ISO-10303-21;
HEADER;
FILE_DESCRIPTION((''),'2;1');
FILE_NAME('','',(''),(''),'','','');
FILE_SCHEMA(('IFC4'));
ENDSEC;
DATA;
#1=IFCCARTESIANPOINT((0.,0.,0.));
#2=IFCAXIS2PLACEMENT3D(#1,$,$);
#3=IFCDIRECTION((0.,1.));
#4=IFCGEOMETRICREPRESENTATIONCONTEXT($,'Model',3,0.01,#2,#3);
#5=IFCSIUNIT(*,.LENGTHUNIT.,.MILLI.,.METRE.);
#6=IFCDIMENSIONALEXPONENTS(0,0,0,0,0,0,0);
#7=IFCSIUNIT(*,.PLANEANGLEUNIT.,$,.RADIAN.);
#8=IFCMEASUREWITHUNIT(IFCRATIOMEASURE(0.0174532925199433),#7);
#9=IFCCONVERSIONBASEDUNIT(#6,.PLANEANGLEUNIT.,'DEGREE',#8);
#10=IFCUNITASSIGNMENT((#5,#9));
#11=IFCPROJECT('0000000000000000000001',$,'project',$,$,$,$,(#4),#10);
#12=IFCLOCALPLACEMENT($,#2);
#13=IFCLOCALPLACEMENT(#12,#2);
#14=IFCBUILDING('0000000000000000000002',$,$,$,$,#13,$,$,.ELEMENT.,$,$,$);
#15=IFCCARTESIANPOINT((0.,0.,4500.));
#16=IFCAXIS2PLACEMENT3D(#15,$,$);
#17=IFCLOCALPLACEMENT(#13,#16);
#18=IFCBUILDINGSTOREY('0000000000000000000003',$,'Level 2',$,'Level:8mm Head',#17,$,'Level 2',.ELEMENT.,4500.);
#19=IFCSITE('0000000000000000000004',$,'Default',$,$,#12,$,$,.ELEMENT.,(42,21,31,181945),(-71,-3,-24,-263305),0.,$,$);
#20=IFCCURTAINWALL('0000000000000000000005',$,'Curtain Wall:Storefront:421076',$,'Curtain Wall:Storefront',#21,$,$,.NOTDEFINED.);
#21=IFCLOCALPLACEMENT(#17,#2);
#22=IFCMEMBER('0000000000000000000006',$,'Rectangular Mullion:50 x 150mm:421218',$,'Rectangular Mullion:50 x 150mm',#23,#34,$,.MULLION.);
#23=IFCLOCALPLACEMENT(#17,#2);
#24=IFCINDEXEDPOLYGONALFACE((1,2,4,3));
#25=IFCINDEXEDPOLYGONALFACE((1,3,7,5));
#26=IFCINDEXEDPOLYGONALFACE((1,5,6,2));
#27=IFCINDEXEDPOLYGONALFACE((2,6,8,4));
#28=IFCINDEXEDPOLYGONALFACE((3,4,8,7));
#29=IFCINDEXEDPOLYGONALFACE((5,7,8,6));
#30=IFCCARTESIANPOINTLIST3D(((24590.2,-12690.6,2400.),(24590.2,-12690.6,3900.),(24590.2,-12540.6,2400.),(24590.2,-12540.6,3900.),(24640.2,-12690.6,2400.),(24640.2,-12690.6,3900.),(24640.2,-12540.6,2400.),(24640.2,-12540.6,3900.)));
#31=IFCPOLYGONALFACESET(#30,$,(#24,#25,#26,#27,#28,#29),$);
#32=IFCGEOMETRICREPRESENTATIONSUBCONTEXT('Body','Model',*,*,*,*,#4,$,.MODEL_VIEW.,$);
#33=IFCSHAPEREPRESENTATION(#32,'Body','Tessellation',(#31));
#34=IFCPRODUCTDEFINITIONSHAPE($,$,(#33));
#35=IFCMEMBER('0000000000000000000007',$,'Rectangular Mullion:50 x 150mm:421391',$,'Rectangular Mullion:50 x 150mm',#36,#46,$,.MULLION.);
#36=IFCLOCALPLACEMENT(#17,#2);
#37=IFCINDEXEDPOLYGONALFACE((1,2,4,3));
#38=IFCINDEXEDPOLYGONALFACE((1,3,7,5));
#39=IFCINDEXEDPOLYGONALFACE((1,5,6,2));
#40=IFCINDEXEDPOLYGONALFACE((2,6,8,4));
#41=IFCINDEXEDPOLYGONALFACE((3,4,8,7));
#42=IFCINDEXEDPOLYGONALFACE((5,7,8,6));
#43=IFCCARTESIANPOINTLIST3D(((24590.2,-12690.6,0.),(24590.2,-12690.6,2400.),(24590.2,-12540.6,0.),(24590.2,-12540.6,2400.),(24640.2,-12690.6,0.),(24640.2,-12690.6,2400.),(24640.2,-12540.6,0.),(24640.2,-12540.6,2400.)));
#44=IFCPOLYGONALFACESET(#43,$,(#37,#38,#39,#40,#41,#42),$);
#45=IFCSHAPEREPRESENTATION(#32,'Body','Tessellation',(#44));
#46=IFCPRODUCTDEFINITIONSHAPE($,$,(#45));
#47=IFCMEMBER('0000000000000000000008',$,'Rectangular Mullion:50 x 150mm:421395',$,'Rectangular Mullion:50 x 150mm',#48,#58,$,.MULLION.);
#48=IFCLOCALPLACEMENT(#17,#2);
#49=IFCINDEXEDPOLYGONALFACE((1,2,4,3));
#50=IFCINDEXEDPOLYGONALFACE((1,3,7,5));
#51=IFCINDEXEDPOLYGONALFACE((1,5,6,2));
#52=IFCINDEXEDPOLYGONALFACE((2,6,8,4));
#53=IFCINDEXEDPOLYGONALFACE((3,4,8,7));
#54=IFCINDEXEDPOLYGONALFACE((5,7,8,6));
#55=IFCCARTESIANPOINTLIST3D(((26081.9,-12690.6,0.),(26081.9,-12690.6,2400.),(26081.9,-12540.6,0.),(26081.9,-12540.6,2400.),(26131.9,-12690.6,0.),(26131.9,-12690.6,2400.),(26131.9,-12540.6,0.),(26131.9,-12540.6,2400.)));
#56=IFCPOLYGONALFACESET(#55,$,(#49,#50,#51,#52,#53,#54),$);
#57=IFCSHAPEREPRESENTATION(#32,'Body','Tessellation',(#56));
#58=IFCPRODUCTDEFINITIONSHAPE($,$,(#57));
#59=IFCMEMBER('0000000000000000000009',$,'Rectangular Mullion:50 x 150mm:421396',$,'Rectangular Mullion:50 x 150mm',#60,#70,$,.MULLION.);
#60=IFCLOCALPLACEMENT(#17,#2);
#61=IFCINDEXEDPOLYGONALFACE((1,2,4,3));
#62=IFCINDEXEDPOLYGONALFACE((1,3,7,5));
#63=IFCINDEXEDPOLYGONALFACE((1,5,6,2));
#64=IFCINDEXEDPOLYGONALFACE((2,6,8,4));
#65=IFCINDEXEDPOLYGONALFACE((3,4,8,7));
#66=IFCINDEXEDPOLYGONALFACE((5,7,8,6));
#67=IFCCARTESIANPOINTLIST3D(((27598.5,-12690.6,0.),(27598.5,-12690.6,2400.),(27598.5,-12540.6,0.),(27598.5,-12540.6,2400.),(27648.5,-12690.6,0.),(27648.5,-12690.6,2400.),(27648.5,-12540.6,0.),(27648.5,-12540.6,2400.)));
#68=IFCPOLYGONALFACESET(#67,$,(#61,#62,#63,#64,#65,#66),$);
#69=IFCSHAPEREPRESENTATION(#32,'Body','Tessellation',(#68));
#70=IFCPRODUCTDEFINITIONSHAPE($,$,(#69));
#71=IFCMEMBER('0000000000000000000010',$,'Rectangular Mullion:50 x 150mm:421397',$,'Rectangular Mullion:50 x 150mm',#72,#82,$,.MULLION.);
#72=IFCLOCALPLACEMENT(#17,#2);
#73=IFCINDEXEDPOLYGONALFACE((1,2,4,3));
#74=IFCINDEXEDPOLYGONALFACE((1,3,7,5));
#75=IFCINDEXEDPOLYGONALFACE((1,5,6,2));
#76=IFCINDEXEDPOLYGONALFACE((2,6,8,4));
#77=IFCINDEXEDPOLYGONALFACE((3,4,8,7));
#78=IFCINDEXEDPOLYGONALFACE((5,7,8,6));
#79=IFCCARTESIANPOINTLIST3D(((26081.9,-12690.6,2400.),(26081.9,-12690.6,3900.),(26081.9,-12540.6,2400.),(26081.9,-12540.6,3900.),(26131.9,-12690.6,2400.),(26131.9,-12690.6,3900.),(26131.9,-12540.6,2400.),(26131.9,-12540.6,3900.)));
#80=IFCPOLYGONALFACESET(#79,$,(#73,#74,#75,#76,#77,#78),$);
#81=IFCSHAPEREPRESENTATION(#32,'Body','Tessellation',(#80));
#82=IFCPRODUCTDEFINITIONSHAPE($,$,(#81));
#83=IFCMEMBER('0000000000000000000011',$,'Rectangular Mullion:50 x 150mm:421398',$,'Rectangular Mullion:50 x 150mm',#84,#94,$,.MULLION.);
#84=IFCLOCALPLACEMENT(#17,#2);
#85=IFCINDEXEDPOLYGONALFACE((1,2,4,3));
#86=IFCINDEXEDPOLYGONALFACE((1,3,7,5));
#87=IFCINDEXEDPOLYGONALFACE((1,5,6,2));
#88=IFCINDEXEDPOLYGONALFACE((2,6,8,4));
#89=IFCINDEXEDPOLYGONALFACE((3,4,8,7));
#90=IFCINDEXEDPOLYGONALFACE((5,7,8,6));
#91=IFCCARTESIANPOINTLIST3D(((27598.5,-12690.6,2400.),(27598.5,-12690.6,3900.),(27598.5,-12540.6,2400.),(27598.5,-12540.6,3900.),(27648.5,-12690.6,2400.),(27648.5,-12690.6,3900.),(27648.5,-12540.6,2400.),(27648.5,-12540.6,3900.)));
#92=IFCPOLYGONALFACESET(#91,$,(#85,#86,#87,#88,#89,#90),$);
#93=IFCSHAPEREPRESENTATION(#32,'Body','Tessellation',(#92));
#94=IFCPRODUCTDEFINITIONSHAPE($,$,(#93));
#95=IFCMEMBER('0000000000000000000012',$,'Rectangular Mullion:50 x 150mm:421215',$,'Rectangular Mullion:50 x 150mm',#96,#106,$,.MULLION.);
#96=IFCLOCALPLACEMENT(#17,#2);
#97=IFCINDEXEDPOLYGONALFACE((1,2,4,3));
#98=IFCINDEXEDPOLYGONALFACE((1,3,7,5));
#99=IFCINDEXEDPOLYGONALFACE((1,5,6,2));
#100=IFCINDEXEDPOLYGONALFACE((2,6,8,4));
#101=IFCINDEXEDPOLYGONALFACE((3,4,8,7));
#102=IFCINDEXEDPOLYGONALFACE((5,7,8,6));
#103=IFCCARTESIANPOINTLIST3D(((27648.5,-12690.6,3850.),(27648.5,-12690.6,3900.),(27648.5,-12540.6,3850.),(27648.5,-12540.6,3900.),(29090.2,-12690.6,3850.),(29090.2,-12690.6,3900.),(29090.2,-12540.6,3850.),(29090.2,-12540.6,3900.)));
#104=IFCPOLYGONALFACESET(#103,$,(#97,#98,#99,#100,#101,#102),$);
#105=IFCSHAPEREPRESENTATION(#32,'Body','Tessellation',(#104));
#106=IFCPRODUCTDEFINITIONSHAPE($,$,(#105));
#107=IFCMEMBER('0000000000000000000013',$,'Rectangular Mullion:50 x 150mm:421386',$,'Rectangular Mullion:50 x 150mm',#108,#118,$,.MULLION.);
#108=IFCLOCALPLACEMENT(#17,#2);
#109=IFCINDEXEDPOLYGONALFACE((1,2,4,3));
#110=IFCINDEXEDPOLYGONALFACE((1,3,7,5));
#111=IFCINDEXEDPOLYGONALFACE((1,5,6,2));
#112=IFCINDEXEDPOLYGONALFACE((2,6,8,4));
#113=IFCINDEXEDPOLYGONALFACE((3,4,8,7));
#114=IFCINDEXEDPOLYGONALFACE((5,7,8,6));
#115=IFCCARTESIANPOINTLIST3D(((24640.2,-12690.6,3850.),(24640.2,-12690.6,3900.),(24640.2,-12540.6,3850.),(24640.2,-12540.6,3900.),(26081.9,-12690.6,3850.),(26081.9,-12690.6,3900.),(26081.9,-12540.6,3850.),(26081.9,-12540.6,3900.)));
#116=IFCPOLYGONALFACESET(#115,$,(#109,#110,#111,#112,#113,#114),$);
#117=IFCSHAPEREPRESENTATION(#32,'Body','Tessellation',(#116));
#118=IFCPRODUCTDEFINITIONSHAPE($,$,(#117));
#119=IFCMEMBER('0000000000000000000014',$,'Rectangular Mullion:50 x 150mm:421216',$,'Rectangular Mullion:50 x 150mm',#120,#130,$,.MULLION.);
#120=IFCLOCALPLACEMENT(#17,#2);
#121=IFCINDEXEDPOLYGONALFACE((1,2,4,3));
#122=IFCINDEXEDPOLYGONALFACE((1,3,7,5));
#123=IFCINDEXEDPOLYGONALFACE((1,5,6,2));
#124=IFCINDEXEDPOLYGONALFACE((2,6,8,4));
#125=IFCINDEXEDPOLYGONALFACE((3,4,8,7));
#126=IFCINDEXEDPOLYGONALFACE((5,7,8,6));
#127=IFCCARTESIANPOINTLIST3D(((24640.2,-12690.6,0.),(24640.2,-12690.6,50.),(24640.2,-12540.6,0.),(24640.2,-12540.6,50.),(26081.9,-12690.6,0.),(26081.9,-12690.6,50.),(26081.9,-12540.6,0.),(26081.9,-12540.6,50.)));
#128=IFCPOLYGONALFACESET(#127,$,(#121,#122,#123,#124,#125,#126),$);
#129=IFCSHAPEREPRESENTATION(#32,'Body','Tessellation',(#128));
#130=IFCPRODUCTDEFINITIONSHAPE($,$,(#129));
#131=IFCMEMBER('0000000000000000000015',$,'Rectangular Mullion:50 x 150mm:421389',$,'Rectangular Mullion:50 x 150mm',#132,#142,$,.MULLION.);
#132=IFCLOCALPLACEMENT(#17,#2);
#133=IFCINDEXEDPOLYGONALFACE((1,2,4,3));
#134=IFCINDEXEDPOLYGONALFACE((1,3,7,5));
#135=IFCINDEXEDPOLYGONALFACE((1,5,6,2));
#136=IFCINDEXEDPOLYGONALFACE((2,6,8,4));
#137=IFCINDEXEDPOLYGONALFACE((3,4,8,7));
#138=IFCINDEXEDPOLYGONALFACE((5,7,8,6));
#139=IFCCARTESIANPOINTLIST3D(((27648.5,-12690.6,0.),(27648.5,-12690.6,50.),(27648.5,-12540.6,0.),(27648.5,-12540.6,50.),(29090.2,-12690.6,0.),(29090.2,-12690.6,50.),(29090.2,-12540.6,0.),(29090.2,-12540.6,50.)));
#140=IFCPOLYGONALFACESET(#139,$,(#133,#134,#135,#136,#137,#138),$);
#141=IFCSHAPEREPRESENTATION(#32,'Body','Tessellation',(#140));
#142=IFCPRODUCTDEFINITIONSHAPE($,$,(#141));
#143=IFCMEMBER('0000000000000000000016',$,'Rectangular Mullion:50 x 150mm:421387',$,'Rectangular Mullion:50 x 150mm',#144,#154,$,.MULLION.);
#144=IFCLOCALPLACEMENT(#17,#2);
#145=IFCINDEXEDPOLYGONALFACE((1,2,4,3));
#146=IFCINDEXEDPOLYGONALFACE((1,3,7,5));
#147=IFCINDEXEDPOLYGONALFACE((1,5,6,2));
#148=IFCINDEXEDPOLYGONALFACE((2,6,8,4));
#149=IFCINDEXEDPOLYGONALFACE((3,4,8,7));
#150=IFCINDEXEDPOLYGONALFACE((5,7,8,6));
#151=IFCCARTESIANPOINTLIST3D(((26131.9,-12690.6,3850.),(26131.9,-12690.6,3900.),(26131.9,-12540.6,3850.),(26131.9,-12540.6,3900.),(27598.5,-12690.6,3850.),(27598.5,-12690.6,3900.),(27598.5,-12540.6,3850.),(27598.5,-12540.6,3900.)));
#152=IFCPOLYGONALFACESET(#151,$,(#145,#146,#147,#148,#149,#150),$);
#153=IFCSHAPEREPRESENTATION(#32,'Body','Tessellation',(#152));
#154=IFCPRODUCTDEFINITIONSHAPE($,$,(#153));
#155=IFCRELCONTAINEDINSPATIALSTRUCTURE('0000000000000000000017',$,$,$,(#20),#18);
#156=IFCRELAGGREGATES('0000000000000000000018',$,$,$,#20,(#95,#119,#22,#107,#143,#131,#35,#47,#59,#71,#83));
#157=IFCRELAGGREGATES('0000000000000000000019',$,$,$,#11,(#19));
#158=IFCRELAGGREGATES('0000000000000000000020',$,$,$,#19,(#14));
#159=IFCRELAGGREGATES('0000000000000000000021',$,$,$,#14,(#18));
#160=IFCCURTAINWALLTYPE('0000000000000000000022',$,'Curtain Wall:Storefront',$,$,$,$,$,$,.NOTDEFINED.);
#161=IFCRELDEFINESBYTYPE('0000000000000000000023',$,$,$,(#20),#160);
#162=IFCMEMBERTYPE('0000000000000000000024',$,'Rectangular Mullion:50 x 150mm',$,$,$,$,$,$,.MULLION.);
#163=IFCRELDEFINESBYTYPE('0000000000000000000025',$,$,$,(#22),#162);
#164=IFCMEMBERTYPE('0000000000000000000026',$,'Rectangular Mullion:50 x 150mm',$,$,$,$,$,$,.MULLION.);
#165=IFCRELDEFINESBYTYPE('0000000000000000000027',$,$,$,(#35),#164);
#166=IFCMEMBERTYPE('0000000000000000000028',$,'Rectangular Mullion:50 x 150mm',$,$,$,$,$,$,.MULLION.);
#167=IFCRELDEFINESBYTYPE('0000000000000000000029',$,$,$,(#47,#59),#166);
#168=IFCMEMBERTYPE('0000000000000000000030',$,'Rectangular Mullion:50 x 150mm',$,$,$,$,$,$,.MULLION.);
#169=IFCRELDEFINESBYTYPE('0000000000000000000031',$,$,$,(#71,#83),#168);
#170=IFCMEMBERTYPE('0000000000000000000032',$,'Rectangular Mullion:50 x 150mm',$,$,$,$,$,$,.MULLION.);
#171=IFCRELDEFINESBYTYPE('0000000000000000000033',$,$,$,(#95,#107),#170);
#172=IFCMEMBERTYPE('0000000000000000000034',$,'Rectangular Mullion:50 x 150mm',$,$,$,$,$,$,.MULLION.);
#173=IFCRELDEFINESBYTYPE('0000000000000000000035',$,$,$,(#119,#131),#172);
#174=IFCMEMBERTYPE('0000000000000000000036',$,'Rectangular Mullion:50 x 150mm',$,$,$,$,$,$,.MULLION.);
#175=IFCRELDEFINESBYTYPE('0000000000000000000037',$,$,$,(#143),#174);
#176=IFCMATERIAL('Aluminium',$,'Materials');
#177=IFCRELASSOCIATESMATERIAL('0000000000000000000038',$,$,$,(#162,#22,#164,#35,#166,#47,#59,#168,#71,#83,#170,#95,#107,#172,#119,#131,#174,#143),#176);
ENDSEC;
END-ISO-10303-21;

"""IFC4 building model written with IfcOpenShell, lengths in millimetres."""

from ifc_helpers import new_model, entity, si_unit, converted_unit, direction, frame, origin, place, context, subcontext, project, spatial, indexed_curve, outline, extrude, source, transform, mapped, material, type_object, type_shapes, element, aggregate, save


model = new_model("IFC4")

# Units and contexts
model_context = context("Model", 3, precision=0.01, world=origin(), true_north=direction((0.0, 1.0)))
body_context = subcontext(model_context, "Body", "Model", "MODEL_VIEW")
ifc_project = project(units=[si_unit("LENGTHUNIT", "METRE", prefix="MILLI"), converted_unit("PLANEANGLEUNIT", "DEGREE", entity("IfcRatioMeasure", 0.0174532925199433), si_unit("PLANEANGLEUNIT", "RADIAN"), dimensions=[0, 0, 0, 0, 0, 0, 0])], contexts=[model_context])

# Site, building, storey
site_placement = place(None, origin())
site = spatial("IfcSite", under=ifc_project, at=site_placement, Name="Default", CompositionType="ELEMENT", RefLatitude=(42, 21, 31, 181945), RefLongitude=(-71, -3, -24, -263305), RefElevation=0.0)
building_placement = place(site_placement, origin())
building = spatial("IfcBuilding", under=site, at=building_placement, CompositionType="ELEMENT")
storey_placement = place(building_placement, frame((0.0, 0.0, 4500.0)))
storey = spatial("IfcBuildingStorey", under=building, at=storey_placement, Name="Level 2", ObjectType="Level:8mm Head", LongName="Level 2", CompositionType="ELEMENT", Elevation=4500.0)

# Curtain wall, members
curtain_wall_type_1 = type_object("IfcCurtainWallType", Name="Curtain Wall:Storefront", PredefinedType="NOTDEFINED")
curtain_wall_1_placement = place(storey_placement, frame((0.0, 0.0, -4500.0)))
curtain_wall_1 = element("IfcCurtainWall", 1, at=curtain_wall_1_placement, inside=storey, type_object=curtain_wall_type_1, Name="Curtain Wall:Storefront:421076", ObjectType="Curtain Wall:Storefront", PredefinedType="NOTDEFINED")
ifc_material_1 = material(Name="Aluminium", Category="Materials")
member_type_1 = type_object("IfcMemberType", Name="Rectangular Mullion:50 x 150mm", PredefinedType="MULLION", material=ifc_material_1)
shared_shape_1 = source(origin(), body_context, "Body", "SweptSolid", [
    extrude(outline(indexed_curve([(-75.0, -25.0), (75.0, -25.0), (75.0, 25.0), (-75.0, 25.0), (-75.0, -25.0)], self_intersect=False)), frame((-25.0, 0.0, -1500.0), z_axis=(0.0, 0.0, 1.0), x_axis=(0.0, -1.0, 0.0)), (0.0, 0.0, 1.0), 1500.0),
])
type_shapes(member_type_1, [shared_shape_1])
member_1_placement = place(storey_placement, frame((24590.2, -12615.6, 3900.0), z_axis=(0.0, 0.0, 1.0), x_axis=(-1.0, 0.0, 0.0)))
member_1 = element("IfcMember", 2, at=member_1_placement, type_object=member_type_1, material=ifc_material_1, Name="Rectangular Mullion:50 x 150mm:421218", ObjectType="Rectangular Mullion:50 x 150mm", PredefinedType="MULLION", context=body_context, shape_type="MappedRepresentation", body=[
    mapped(shared_shape_1, transform((0.0, 0.0, 0.0), scale=1.0)),
])
member_type_2 = type_object("IfcMemberType", Name="Rectangular Mullion:50 x 150mm", PredefinedType="MULLION", material=ifc_material_1)
shared_shape_2 = source(origin(), body_context, "Body", "SweptSolid", [
    extrude(outline(indexed_curve([(-75.0, -25.0), (75.0, -25.0), (75.0, 25.0), (-75.0, 25.0), (-75.0, -25.0)], self_intersect=False)), frame((-25.0, 0.0, -2400.0), z_axis=(0.0, 0.0, 1.0), x_axis=(0.0, -1.0, 0.0)), (0.0, 0.0, 1.0), 2400.0),
])
type_shapes(member_type_2, [shared_shape_2])
member_2_placement = place(storey_placement, frame((24590.2, -12615.6, 2400.0), z_axis=(0.0, 0.0, 1.0), x_axis=(-1.0, 0.0, 0.0)))
member_2 = element("IfcMember", 3, at=member_2_placement, type_object=member_type_2, material=ifc_material_1, Name="Rectangular Mullion:50 x 150mm:421391", ObjectType="Rectangular Mullion:50 x 150mm", PredefinedType="MULLION", context=body_context, shape_type="MappedRepresentation", body=[
    mapped(shared_shape_2, transform((0.0, 0.0, 0.0), scale=1.0)),
])
member_type_3 = type_object("IfcMemberType", Name="Rectangular Mullion:50 x 150mm", PredefinedType="MULLION", material=ifc_material_1)
shared_shape_3 = source(origin(), body_context, "Body", "SweptSolid", [
    extrude(outline(indexed_curve([(-75.0, -25.0), (75.0, -25.0), (75.0, 25.0), (-75.0, 25.0), (-75.0, -25.0)], self_intersect=False)), frame((0.0, 0.0, -2400.0), z_axis=(0.0, 0.0, 1.0), x_axis=(0.0, -1.0, 0.0)), (0.0, 0.0, 1.0), 2400.0),
])
type_shapes(member_type_3, [shared_shape_3])
member_3_placement = place(storey_placement, frame((26106.9, -12615.6, 0.0), z_axis=(0.0, 0.0, -1.0), x_axis=(1.0, 0.0, 0.0)))
member_3 = element("IfcMember", 4, at=member_3_placement, type_object=member_type_3, material=ifc_material_1, Name="Rectangular Mullion:50 x 150mm:421395", ObjectType="Rectangular Mullion:50 x 150mm", PredefinedType="MULLION", context=body_context, shape_type="MappedRepresentation", body=[
    mapped(shared_shape_3, transform((0.0, 0.0, 0.0), scale=1.0)),
])
member_4_placement = place(storey_placement, frame((27623.5, -12615.6, 0.0), z_axis=(0.0, 0.0, -1.0), x_axis=(1.0, 0.0, 0.0)))
member_4 = element("IfcMember", 5, at=member_4_placement, type_object=member_type_3, material=ifc_material_1, Name="Rectangular Mullion:50 x 150mm:421396", ObjectType="Rectangular Mullion:50 x 150mm", PredefinedType="MULLION", context=body_context, shape_type="MappedRepresentation", body=[
    mapped(shared_shape_3, transform((0.0, 0.0, 0.0), scale=1.0)),
])
member_type_4 = type_object("IfcMemberType", Name="Rectangular Mullion:50 x 150mm", PredefinedType="MULLION", material=ifc_material_1)
shared_shape_4 = source(origin(), body_context, "Body", "SweptSolid", [
    extrude(outline(indexed_curve([(-75.0, -25.0), (75.0, -25.0), (75.0, 25.0), (-75.0, 25.0), (-75.0, -25.0)], self_intersect=False)), frame((0.0, 0.0, -1500.0), z_axis=(0.0, 0.0, 1.0), x_axis=(0.0, -1.0, 0.0)), (0.0, 0.0, 1.0), 1500.0),
])
type_shapes(member_type_4, [shared_shape_4])
member_5_placement = place(storey_placement, frame((26106.9, -12615.6, 2400.0), z_axis=(0.0, 0.0, -1.0), x_axis=(1.0, 0.0, 0.0)))
member_5 = element("IfcMember", 6, at=member_5_placement, type_object=member_type_4, material=ifc_material_1, Name="Rectangular Mullion:50 x 150mm:421397", ObjectType="Rectangular Mullion:50 x 150mm", PredefinedType="MULLION", context=body_context, shape_type="MappedRepresentation", body=[
    mapped(shared_shape_4, transform((0.0, 0.0, 0.0), scale=1.0)),
])
member_6_placement = place(storey_placement, frame((27623.5, -12615.6, 2400.0), z_axis=(0.0, 0.0, -1.0), x_axis=(1.0, 0.0, 0.0)))
member_6 = element("IfcMember", 7, at=member_6_placement, type_object=member_type_4, material=ifc_material_1, Name="Rectangular Mullion:50 x 150mm:421398", ObjectType="Rectangular Mullion:50 x 150mm", PredefinedType="MULLION", context=body_context, shape_type="MappedRepresentation", body=[
    mapped(shared_shape_4, transform((0.0, 0.0, 0.0), scale=1.0)),
])
member_type_5 = type_object("IfcMemberType", Name="Rectangular Mullion:50 x 150mm", PredefinedType="MULLION", material=ifc_material_1)
shared_shape_5 = source(origin(), body_context, "Body", "SweptSolid", [
    extrude(outline(indexed_curve([(-75.0, -25.0), (75.0, -25.0), (75.0, 25.0), (-75.0, 25.0), (-75.0, -25.0)], self_intersect=False)), frame((-25.0, 0.0, -1441.7), z_axis=(0.0, 0.0, 1.0), x_axis=(0.0, -1.0, 0.0)), (0.0, 0.0, 1.0), 1441.7),
])
type_shapes(member_type_5, [shared_shape_5])
member_7_placement = place(storey_placement, frame((29090.2, -12615.6, 3900.0), z_axis=(1.0, 0.0, 0.0), x_axis=(0.0, 0.0, 1.0)))
member_7 = element("IfcMember", 8, at=member_7_placement, type_object=member_type_5, material=ifc_material_1, Name="Rectangular Mullion:50 x 150mm:421215", ObjectType="Rectangular Mullion:50 x 150mm", PredefinedType="MULLION", context=body_context, shape_type="MappedRepresentation", body=[
    mapped(shared_shape_5, transform((0.0, 0.0, 0.0), scale=1.0)),
])
member_8_placement = place(storey_placement, frame((26081.9, -12615.6, 3900.0), z_axis=(1.0, 0.0, 0.0), x_axis=(0.0, 0.0, 1.0)))
member_8 = element("IfcMember", 9, at=member_8_placement, type_object=member_type_5, material=ifc_material_1, Name="Rectangular Mullion:50 x 150mm:421386", ObjectType="Rectangular Mullion:50 x 150mm", PredefinedType="MULLION", context=body_context, shape_type="MappedRepresentation", body=[
    mapped(shared_shape_5, transform((0.0, 0.0, 0.0), scale=1.0)),
])
member_type_6 = type_object("IfcMemberType", Name="Rectangular Mullion:50 x 150mm", PredefinedType="MULLION", material=ifc_material_1)
shared_shape_6 = source(origin(), body_context, "Body", "SweptSolid", [
    extrude(outline(indexed_curve([(-75.0, -25.0), (75.0, -25.0), (75.0, 25.0), (-75.0, 25.0), (-75.0, -25.0)], self_intersect=False)), frame((-25.0, 0.0, -1441.7), z_axis=(0.0, 0.0, 1.0), x_axis=(0.0, -1.0, 0.0)), (0.0, 0.0, 1.0), 1441.7),
])
type_shapes(member_type_6, [shared_shape_6])
member_9_placement = place(storey_placement, frame((24640.2, -12615.6, 0.0), z_axis=(-1.0, 0.0, 0.0), x_axis=(0.0, 0.0, -1.0)))
member_9 = element("IfcMember", 10, at=member_9_placement, type_object=member_type_6, material=ifc_material_1, Name="Rectangular Mullion:50 x 150mm:421216", ObjectType="Rectangular Mullion:50 x 150mm", PredefinedType="MULLION", context=body_context, shape_type="MappedRepresentation", body=[
    mapped(shared_shape_6, transform((0.0, 0.0, 0.0), scale=1.0)),
])
member_10_placement = place(storey_placement, frame((27648.5, -12615.6, 0.0), z_axis=(-1.0, 0.0, 0.0), x_axis=(0.0, 0.0, -1.0)))
member_10 = element("IfcMember", 11, at=member_10_placement, type_object=member_type_6, material=ifc_material_1, Name="Rectangular Mullion:50 x 150mm:421389", ObjectType="Rectangular Mullion:50 x 150mm", PredefinedType="MULLION", context=body_context, shape_type="MappedRepresentation", body=[
    mapped(shared_shape_6, transform((0.0, 0.0, 0.0), scale=1.0)),
])
member_type_7 = type_object("IfcMemberType", Name="Rectangular Mullion:50 x 150mm", PredefinedType="MULLION", material=ifc_material_1)
shared_shape_7 = source(origin(), body_context, "Body", "SweptSolid", [
    extrude(outline(indexed_curve([(-75.0, -25.0), (75.0, -25.0), (75.0, 25.0), (-75.0, 25.0), (-75.0, -25.0)], self_intersect=False)), frame((-25.0, 0.0, -1466.7), z_axis=(0.0, 0.0, 1.0), x_axis=(0.0, -1.0, 0.0)), (0.0, 0.0, 1.0), 1466.7),
])
type_shapes(member_type_7, [shared_shape_7])
member_11_placement = place(storey_placement, frame((27598.5, -12615.6, 3900.0), z_axis=(1.0, 0.0, 0.0), x_axis=(0.0, 0.0, 1.0)))
member_11 = element("IfcMember", 12, at=member_11_placement, type_object=member_type_7, material=ifc_material_1, Name="Rectangular Mullion:50 x 150mm:421387", ObjectType="Rectangular Mullion:50 x 150mm", PredefinedType="MULLION", context=body_context, shape_type="MappedRepresentation", body=[
    mapped(shared_shape_7, transform((0.0, 0.0, 0.0), scale=1.0)),
])

aggregate(curtain_wall_1, [member_7, member_9, member_1, member_8, member_11, member_10, member_2, member_3, member_4, member_5, member_6])

save(model, "model.ifc")
